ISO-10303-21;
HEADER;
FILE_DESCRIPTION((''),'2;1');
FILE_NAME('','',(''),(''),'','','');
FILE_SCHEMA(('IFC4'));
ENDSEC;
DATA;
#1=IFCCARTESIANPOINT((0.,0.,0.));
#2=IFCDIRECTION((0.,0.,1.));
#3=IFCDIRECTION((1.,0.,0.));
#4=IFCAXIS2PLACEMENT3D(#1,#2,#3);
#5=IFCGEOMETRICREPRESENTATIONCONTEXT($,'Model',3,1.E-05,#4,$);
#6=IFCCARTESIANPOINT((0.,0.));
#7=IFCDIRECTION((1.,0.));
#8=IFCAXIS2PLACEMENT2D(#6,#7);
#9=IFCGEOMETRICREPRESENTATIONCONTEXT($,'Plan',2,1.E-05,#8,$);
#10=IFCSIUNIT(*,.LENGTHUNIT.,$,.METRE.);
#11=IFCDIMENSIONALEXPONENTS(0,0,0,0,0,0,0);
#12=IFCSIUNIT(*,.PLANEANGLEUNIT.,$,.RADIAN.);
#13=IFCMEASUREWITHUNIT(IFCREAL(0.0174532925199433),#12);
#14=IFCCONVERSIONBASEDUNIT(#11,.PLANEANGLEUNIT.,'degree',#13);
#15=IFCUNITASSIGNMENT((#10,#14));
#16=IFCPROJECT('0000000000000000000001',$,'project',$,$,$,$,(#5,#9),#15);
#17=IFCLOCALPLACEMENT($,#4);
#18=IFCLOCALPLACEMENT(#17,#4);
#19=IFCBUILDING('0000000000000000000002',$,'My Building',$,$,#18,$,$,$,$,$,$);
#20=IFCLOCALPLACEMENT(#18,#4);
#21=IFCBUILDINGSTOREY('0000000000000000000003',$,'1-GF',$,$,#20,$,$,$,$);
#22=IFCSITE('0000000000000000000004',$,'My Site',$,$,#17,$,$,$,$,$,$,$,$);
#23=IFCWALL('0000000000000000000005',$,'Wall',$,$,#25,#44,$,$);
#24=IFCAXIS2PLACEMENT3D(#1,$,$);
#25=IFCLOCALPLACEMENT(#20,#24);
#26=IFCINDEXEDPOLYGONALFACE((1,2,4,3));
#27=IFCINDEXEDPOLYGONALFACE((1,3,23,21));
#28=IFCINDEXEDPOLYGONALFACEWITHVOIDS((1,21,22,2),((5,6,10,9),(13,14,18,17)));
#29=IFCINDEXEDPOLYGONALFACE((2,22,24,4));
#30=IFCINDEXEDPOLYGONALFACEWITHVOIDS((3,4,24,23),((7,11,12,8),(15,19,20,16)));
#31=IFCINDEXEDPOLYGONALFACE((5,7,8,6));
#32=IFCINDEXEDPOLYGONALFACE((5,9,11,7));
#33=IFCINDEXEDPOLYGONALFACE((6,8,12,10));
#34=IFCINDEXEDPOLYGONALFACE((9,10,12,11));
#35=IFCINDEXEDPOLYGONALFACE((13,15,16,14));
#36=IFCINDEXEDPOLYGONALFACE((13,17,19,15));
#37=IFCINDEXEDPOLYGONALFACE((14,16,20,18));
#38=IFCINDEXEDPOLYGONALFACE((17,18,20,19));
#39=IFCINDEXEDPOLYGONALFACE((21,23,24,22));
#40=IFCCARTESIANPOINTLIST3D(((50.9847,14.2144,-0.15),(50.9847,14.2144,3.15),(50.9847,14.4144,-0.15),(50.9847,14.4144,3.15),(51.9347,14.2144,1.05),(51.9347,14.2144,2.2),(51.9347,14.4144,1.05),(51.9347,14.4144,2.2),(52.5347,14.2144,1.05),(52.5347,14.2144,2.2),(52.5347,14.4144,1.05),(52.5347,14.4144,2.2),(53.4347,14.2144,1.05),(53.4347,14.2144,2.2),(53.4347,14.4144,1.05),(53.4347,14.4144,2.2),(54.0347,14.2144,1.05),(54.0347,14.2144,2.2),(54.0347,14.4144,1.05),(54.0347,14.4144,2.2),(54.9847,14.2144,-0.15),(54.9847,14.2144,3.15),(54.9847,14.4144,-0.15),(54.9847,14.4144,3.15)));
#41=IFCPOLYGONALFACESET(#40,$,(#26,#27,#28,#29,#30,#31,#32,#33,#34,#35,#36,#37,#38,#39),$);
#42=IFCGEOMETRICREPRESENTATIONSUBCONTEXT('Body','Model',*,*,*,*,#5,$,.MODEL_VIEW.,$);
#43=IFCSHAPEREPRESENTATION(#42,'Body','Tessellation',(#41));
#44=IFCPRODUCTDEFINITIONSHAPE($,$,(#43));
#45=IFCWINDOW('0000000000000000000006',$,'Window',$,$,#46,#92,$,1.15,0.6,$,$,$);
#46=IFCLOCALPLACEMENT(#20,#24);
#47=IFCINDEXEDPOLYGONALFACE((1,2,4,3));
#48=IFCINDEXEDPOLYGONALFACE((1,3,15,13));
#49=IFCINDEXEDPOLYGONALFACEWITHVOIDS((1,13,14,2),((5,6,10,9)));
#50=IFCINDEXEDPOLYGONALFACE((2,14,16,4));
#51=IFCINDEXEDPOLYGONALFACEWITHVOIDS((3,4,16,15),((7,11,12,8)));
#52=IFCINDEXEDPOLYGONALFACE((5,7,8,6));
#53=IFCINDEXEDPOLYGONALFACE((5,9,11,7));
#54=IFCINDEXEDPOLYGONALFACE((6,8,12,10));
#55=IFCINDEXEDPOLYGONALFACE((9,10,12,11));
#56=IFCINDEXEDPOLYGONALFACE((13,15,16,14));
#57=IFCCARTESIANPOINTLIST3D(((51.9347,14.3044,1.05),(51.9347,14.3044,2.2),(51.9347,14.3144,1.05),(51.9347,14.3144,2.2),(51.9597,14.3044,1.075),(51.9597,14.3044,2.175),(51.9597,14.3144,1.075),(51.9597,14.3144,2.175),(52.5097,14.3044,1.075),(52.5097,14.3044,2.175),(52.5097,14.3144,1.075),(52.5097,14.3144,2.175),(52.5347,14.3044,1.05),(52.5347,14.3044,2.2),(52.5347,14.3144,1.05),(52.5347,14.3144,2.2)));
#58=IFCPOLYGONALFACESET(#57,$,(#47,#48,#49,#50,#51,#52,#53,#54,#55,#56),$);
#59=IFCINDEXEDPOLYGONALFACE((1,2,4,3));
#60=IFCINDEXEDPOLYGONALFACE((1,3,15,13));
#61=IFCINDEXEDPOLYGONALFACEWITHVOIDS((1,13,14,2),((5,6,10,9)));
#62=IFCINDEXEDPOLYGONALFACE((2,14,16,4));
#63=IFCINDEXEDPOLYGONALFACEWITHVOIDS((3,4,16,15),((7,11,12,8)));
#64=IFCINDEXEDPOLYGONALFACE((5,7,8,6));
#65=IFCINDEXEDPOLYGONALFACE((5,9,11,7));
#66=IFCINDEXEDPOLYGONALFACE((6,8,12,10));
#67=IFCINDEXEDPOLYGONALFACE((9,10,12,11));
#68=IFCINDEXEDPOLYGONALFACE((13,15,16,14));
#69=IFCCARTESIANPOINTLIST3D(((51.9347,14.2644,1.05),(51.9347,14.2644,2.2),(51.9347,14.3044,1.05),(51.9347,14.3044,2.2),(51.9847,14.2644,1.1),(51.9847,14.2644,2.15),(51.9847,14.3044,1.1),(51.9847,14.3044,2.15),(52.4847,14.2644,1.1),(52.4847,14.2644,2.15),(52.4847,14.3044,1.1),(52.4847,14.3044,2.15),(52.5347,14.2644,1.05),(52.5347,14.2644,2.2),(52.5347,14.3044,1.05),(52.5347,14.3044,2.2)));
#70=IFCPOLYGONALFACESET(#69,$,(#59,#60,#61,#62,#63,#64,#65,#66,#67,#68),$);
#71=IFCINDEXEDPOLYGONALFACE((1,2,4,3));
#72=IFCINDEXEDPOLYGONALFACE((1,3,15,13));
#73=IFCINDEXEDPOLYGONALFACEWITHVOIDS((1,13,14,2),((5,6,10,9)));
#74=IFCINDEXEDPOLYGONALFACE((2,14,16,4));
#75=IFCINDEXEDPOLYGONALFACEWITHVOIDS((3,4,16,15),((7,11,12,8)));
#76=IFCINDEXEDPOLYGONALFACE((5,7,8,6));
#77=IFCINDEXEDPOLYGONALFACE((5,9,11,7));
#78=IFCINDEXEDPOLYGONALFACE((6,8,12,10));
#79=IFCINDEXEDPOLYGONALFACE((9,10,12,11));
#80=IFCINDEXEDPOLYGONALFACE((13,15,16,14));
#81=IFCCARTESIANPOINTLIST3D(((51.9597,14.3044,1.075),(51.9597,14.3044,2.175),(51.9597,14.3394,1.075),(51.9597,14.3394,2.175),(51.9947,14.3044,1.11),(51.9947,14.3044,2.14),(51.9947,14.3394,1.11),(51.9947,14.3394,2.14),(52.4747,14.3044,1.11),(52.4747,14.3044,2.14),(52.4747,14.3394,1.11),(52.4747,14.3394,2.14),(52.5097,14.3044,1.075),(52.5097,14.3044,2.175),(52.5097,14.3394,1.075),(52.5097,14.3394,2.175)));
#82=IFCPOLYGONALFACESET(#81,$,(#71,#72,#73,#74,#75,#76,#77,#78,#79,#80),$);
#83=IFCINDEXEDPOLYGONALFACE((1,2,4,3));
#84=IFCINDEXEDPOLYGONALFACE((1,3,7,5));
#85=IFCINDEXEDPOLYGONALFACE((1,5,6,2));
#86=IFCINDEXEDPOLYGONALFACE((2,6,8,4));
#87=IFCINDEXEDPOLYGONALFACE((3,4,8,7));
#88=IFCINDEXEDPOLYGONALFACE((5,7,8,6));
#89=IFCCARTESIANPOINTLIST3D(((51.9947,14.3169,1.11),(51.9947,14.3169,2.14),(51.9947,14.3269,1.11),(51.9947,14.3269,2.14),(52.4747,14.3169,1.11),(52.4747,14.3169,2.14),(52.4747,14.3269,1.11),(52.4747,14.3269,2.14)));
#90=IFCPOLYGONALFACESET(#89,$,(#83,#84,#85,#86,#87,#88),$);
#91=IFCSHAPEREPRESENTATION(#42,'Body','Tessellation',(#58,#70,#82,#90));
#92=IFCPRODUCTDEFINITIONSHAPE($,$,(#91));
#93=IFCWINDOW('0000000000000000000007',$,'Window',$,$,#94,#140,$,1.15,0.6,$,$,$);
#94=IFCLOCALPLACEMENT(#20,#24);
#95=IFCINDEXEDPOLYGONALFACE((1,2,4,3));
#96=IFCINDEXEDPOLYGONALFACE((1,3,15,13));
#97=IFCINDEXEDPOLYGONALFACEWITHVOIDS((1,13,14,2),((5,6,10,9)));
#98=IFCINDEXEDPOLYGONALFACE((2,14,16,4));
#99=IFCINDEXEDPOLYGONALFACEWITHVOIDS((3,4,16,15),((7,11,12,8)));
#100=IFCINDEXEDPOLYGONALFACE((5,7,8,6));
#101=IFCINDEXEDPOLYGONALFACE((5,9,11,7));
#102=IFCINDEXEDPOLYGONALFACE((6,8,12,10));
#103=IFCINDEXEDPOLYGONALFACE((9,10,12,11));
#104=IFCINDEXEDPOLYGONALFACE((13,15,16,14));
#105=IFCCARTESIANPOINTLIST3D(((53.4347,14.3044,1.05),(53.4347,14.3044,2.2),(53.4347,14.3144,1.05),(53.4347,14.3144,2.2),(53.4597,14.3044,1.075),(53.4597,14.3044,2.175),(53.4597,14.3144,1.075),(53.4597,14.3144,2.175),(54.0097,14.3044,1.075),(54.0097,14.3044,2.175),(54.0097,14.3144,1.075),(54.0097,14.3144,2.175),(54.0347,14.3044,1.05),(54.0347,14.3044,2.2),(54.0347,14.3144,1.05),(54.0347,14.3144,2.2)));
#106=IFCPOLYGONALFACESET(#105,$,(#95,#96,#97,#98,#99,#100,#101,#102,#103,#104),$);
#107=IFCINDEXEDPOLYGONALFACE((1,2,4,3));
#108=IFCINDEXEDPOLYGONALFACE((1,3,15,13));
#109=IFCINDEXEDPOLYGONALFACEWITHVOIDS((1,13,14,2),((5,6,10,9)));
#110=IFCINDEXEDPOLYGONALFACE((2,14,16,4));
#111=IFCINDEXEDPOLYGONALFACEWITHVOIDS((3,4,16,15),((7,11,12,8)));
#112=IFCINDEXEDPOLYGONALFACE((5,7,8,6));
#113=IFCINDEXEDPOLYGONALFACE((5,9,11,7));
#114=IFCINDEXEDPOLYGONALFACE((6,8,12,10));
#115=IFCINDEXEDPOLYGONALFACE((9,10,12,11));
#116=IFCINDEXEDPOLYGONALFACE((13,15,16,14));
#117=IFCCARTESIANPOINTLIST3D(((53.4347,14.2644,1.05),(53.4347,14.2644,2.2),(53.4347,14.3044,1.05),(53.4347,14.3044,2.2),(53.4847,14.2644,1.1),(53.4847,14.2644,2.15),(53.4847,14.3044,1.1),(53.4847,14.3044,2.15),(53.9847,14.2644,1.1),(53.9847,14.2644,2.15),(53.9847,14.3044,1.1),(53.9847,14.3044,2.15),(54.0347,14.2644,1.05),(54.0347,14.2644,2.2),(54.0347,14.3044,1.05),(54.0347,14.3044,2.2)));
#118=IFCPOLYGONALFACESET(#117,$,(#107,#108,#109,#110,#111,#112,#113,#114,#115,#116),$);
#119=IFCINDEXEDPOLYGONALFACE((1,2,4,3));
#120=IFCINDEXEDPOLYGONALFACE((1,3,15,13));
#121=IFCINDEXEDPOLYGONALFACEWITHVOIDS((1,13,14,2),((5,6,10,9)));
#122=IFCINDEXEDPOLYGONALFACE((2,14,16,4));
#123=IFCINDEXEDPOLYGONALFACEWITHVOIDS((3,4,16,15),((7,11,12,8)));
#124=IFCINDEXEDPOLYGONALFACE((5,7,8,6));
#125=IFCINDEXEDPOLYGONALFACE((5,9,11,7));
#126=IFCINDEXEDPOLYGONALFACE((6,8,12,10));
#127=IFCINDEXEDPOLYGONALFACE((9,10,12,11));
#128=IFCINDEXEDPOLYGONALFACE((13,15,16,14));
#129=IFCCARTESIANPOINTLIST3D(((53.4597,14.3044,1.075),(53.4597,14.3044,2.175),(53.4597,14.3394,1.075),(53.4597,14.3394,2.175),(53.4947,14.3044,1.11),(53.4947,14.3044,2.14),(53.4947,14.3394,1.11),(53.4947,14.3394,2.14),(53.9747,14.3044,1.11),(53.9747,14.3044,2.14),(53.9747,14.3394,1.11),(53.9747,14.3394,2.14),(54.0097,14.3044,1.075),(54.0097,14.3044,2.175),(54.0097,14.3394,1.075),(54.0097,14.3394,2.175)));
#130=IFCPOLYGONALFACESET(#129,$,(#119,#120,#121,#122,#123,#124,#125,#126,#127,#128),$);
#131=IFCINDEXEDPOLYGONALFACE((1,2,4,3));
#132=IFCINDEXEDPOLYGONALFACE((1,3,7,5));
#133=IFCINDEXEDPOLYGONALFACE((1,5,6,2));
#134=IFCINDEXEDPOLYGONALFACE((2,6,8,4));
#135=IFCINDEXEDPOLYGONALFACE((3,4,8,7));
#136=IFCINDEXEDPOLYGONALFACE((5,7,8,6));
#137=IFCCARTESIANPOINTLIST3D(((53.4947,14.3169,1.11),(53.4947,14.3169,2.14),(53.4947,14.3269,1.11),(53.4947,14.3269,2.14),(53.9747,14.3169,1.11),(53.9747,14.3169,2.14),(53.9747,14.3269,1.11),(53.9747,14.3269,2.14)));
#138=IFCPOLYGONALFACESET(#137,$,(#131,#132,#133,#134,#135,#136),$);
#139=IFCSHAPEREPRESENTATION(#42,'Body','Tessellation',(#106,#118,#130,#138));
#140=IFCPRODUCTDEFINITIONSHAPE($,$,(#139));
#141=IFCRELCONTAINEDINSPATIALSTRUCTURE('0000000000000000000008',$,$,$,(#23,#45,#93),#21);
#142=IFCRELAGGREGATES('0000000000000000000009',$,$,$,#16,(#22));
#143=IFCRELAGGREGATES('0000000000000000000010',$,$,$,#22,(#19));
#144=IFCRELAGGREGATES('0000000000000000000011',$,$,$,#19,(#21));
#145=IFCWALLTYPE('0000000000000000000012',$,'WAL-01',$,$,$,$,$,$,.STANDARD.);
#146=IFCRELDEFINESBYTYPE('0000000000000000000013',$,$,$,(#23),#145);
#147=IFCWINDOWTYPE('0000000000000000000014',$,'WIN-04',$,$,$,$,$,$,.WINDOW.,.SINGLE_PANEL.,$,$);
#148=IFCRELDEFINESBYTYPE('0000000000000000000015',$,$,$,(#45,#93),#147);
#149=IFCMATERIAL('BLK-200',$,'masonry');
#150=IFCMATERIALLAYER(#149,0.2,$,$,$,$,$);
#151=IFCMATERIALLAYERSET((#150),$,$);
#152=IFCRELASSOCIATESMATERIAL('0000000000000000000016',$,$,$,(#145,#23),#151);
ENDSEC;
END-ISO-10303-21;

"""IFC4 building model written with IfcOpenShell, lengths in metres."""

from ifc_helpers import new_model, entity, si_unit, converted_unit, frame, origin_with_axes, origin_2d_with_axis, place, context, subcontext, project, spatial, line, indexed_curve, outline, extrude, shape, source, transform, mapped, material, layer, layer_set, layer_usage, type_object, type_shapes, element, fill, save


model = new_model("IFC4")

# Units and contexts
model_context = context("Model", 3, precision=1e-05, world=origin_with_axes())
plan_context = context("Plan", 2, precision=1e-05, world=origin_2d_with_axis())
body_context_1 = subcontext(model_context, "Body", "Model", "MODEL_VIEW")
body_context_2 = subcontext(plan_context, "Body", "Plan", "PLAN_VIEW")
ifc_project = project(units=[si_unit("LENGTHUNIT", "METRE"), converted_unit("PLANEANGLEUNIT", "degree", entity("IfcReal", 0.0174532925199433), si_unit("PLANEANGLEUNIT", "RADIAN"), dimensions=[0, 0, 0, 0, 0, 0, 0])], contexts=[model_context, plan_context])

# Site, building, storey
site_placement = place(None, origin_with_axes())
site = spatial("IfcSite", under=ifc_project, at=site_placement, Name="My Site")
building_placement = place(site_placement, origin_with_axes())
building = spatial("IfcBuilding", under=site, at=building_placement, Name="My Building")
storey_placement = place(building_placement, origin_with_axes())
storey = spatial("IfcBuildingStorey", under=building, at=storey_placement, Name="1-GF")

# Wall, openings, windows
ifc_material_1 = material(Name="BLK-200", Category="masonry")
ifc_layer_1 = layer(ifc_material_1, 0.2)
ifc_layer_set_1 = layer_set([ifc_layer_1])
ifc_layer_usage_1 = layer_usage(ifc_layer_set_1, "AXIS2", "POSITIVE", 0.0)
wall_type_1 = type_object("IfcWallType", Name="WAL-01", PredefinedType="STANDARD", material=ifc_layer_set_1)
wall_1_placement = place(storey_placement, frame((50.9847, 14.2144, -0.15), z_axis=(0.0, 0.0, 1.0), x_axis=(1.0, 0.0, 0.0)))
wall_1 = element("IfcWall", 1, at=wall_1_placement, inside=storey, type_object=wall_type_1, material=ifc_layer_usage_1, Name="Wall", context=body_context_1, shape_type="SweptSolid", body=[
    extrude(outline(indexed_curve([(0.0, 0.0), (0.0, 0.2), (4.0, 0.2), (4.0, 0.0), (0.0, 0.0)], self_intersect=False)), origin_with_axes(), (0.0, 0.0, 1.0), 3.3),
])
shared_shape_1 = source(origin_with_axes(), body_context_1, "Body", "SweptSolid", [
    extrude(outline(indexed_curve([(0.0, 0.0), (0.6, 0.0), (0.6, 1.15), (0.0, 1.15)], segments=[line(1, 2, 3, 4, 1)])), frame((0.0, -0.6, 0.0), z_axis=(0.0, -1.0, 0.0), x_axis=(1.0, 0.0, 0.0)), (0.0, 0.0, -1.0), 1.2),
])
opening_1_placement = place(wall_1_placement, frame((0.95, 0.0, 1.2), z_axis=(0.0, 0.0, 1.0), x_axis=(1.0, 0.0, 0.0)))
opening_1 = element("IfcOpeningElement", 2, at=opening_1_placement, cuts=wall_1, PredefinedType="OPENING", context=body_context_1, shape_type="MappedRepresentation", body=[
    mapped(shared_shape_1, transform((0.0, 0.0, 0.0), x_axis=(1.0, 0.0, 0.0), y_axis=(0.0, 1.0, 0.0), z_axis=(0.0, 0.0, 1.0), scale=1.0)),
])
opening_2_placement = place(wall_1_placement, frame((2.45, 0.0, 1.2), z_axis=(0.0, 0.0, 1.0), x_axis=(1.0, 0.0, 0.0)))
opening_2 = element("IfcOpeningElement", 3, at=opening_2_placement, cuts=wall_1, PredefinedType="OPENING", context=body_context_1, shape_type="MappedRepresentation", body=[
    mapped(shared_shape_1, transform((0.0, 0.0, 0.0), x_axis=(1.0, 0.0, 0.0), y_axis=(0.0, 1.0, 0.0), z_axis=(0.0, 0.0, 1.0), scale=1.0)),
])
window_type_1 = type_object("IfcWindowType", Name="WIN-04", PartitioningType="SINGLE_PANEL", PredefinedType="WINDOW")
shared_shape_2 = source(origin_with_axes(), body_context_1, "Body", "SweptSolid", [
    extrude(outline(indexed_curve([(0.0, 0.0), (0.6, 0.0), (0.6, 1.15), (0.0, 1.15)], segments=[line(1, 2, 3, 4, 1)]), holes=[indexed_curve([(0.025, 0.025), (0.575, 0.025), (0.575, 1.125), (0.025, 1.125)], segments=[line(1, 2, 3, 4, 1)])]), frame((0.0, 0.09, 0.0), z_axis=(0.0, -1.0, 0.0), x_axis=(1.0, 0.0, 0.0)), (0.0, 0.0, -1.0), 0.01),
    extrude(outline(indexed_curve([(0.0, 0.0), (0.6, 0.0), (0.6, 1.15), (0.0, 1.15)], segments=[line(1, 2, 3, 4, 1)]), holes=[indexed_curve([(0.05, 0.05), (0.55, 0.05), (0.55, 1.1), (0.05, 1.1)], segments=[line(1, 2, 3, 4, 1)])]), frame((0.0, 0.05, 0.0), z_axis=(0.0, -1.0, 0.0), x_axis=(1.0, 0.0, 0.0)), (0.0, 0.0, -1.0), 0.04),
    extrude(outline(indexed_curve([(0.0, 0.0), (0.55, 0.0), (0.55, 1.1), (0.0, 1.1)], segments=[line(1, 2, 3, 4, 1)]), holes=[indexed_curve([(0.035, 0.035), (0.515, 0.035), (0.515, 1.065), (0.035, 1.065)], segments=[line(1, 2, 3, 4, 1)])]), frame((0.025, 0.09, 0.025), z_axis=(0.0, -1.0, 0.0), x_axis=(1.0, 0.0, 0.0)), (0.0, 0.0, -1.0), 0.035),
    extrude(outline(indexed_curve([(0.035, 0.035), (0.515, 0.035), (0.515, 1.065), (0.035, 1.065)], segments=[line(1, 2, 3, 4, 1)])), frame((0.025, 0.1025, 0.025), z_axis=(0.0, -1.0, 0.0), x_axis=(1.0, 0.0, 0.0)), (0.0, 0.0, -1.0), 0.01),
])
shared_shape_3 = source(origin_with_axes(), body_context_2, "Body", "Curve2D", [
    entity("IfcIndexedPolyCurve", entity("IfcCartesianPointList2D", [[0.05, 0.05], [0.55, 0.05]])),
    entity("IfcIndexedPolyCurve", entity("IfcCartesianPointList2D", [[0.0, 0.1], [0.025, 0.1], [0.025, 0.09], [0.05, 0.09], [0.05, 0.05], [0.0, 0.05]]), [entity("IfcLineIndex", [1, 2, 3, 4, 5, 6, 1])]),
    entity("IfcIndexedPolyCurve", entity("IfcCartesianPointList2D", [[0.6, 0.1], [0.575, 0.1], [0.575, 0.09], [0.55, 0.09], [0.55, 0.05], [0.6, 0.05]]), [entity("IfcLineIndex", [1, 2, 3, 4, 5, 6, 1])]),
    entity("IfcIndexedPolyCurve", entity("IfcCartesianPointList2D", [[0.025, 0.09], [0.06, 0.09], [0.06, 0.125], [0.025, 0.125]]), [entity("IfcLineIndex", [1, 2, 3, 4, 1])]),
    entity("IfcIndexedPolyCurve", entity("IfcCartesianPointList2D", [[0.575, 0.09], [0.54, 0.09], [0.54, 0.125], [0.575, 0.125]]), [entity("IfcLineIndex", [1, 2, 3, 4, 1])]),
    entity("IfcIndexedPolyCurve", entity("IfcCartesianPointList2D", [[0.06, 0.09], [0.54, 0.09]])),
    entity("IfcIndexedPolyCurve", entity("IfcCartesianPointList2D", [[0.06, 0.125], [0.54, 0.125]])),
    entity("IfcIndexedPolyCurve", entity("IfcCartesianPointList2D", [[0.06, 0.1075], [0.54, 0.1075]])),
])
type_shapes(window_type_1, [shared_shape_2, shared_shape_3])
window_1_placement = place(opening_1_placement, origin_with_axes())
window_1 = element("IfcWindow", 4, at=window_1_placement, inside=storey, type_object=window_type_1, Name="Window", OverallHeight=1.15, OverallWidth=0.6, shapes=[
    shape(body_context_1, "Body", "MappedRepresentation", [mapped(shared_shape_2, transform((0.0, 0.0, 0.0), x_axis=(1.0, 0.0, 0.0), y_axis=(0.0, 1.0, 0.0), z_axis=(0.0, 0.0, 1.0), scale=1.0))]),
    shape(body_context_2, "Body", "MappedRepresentation", [mapped(shared_shape_3, transform((0.0, 0.0, 0.0), x_axis=(1.0, 0.0, 0.0), y_axis=(0.0, 1.0, 0.0), z_axis=(0.0, 0.0, 1.0), scale=1.0))]),
])
fill(opening_1, window_1)
window_2_placement = place(opening_2_placement, origin_with_axes())
window_2 = element("IfcWindow", 5, at=window_2_placement, inside=storey, type_object=window_type_1, Name="Window", OverallHeight=1.15, OverallWidth=0.6, shapes=[
    shape(body_context_1, "Body", "MappedRepresentation", [mapped(shared_shape_2, transform((0.0, 0.0, 0.0), x_axis=(1.0, 0.0, 0.0), y_axis=(0.0, 1.0, 0.0), z_axis=(0.0, 0.0, 1.0), scale=1.0))]),
    shape(body_context_2, "Body", "MappedRepresentation", [mapped(shared_shape_3, transform((0.0, 0.0, 0.0), x_axis=(1.0, 0.0, 0.0), y_axis=(0.0, 1.0, 0.0), z_axis=(0.0, 0.0, 1.0), scale=1.0))]),
])
fill(opening_2, window_2)

save(model, "model.ifc")
